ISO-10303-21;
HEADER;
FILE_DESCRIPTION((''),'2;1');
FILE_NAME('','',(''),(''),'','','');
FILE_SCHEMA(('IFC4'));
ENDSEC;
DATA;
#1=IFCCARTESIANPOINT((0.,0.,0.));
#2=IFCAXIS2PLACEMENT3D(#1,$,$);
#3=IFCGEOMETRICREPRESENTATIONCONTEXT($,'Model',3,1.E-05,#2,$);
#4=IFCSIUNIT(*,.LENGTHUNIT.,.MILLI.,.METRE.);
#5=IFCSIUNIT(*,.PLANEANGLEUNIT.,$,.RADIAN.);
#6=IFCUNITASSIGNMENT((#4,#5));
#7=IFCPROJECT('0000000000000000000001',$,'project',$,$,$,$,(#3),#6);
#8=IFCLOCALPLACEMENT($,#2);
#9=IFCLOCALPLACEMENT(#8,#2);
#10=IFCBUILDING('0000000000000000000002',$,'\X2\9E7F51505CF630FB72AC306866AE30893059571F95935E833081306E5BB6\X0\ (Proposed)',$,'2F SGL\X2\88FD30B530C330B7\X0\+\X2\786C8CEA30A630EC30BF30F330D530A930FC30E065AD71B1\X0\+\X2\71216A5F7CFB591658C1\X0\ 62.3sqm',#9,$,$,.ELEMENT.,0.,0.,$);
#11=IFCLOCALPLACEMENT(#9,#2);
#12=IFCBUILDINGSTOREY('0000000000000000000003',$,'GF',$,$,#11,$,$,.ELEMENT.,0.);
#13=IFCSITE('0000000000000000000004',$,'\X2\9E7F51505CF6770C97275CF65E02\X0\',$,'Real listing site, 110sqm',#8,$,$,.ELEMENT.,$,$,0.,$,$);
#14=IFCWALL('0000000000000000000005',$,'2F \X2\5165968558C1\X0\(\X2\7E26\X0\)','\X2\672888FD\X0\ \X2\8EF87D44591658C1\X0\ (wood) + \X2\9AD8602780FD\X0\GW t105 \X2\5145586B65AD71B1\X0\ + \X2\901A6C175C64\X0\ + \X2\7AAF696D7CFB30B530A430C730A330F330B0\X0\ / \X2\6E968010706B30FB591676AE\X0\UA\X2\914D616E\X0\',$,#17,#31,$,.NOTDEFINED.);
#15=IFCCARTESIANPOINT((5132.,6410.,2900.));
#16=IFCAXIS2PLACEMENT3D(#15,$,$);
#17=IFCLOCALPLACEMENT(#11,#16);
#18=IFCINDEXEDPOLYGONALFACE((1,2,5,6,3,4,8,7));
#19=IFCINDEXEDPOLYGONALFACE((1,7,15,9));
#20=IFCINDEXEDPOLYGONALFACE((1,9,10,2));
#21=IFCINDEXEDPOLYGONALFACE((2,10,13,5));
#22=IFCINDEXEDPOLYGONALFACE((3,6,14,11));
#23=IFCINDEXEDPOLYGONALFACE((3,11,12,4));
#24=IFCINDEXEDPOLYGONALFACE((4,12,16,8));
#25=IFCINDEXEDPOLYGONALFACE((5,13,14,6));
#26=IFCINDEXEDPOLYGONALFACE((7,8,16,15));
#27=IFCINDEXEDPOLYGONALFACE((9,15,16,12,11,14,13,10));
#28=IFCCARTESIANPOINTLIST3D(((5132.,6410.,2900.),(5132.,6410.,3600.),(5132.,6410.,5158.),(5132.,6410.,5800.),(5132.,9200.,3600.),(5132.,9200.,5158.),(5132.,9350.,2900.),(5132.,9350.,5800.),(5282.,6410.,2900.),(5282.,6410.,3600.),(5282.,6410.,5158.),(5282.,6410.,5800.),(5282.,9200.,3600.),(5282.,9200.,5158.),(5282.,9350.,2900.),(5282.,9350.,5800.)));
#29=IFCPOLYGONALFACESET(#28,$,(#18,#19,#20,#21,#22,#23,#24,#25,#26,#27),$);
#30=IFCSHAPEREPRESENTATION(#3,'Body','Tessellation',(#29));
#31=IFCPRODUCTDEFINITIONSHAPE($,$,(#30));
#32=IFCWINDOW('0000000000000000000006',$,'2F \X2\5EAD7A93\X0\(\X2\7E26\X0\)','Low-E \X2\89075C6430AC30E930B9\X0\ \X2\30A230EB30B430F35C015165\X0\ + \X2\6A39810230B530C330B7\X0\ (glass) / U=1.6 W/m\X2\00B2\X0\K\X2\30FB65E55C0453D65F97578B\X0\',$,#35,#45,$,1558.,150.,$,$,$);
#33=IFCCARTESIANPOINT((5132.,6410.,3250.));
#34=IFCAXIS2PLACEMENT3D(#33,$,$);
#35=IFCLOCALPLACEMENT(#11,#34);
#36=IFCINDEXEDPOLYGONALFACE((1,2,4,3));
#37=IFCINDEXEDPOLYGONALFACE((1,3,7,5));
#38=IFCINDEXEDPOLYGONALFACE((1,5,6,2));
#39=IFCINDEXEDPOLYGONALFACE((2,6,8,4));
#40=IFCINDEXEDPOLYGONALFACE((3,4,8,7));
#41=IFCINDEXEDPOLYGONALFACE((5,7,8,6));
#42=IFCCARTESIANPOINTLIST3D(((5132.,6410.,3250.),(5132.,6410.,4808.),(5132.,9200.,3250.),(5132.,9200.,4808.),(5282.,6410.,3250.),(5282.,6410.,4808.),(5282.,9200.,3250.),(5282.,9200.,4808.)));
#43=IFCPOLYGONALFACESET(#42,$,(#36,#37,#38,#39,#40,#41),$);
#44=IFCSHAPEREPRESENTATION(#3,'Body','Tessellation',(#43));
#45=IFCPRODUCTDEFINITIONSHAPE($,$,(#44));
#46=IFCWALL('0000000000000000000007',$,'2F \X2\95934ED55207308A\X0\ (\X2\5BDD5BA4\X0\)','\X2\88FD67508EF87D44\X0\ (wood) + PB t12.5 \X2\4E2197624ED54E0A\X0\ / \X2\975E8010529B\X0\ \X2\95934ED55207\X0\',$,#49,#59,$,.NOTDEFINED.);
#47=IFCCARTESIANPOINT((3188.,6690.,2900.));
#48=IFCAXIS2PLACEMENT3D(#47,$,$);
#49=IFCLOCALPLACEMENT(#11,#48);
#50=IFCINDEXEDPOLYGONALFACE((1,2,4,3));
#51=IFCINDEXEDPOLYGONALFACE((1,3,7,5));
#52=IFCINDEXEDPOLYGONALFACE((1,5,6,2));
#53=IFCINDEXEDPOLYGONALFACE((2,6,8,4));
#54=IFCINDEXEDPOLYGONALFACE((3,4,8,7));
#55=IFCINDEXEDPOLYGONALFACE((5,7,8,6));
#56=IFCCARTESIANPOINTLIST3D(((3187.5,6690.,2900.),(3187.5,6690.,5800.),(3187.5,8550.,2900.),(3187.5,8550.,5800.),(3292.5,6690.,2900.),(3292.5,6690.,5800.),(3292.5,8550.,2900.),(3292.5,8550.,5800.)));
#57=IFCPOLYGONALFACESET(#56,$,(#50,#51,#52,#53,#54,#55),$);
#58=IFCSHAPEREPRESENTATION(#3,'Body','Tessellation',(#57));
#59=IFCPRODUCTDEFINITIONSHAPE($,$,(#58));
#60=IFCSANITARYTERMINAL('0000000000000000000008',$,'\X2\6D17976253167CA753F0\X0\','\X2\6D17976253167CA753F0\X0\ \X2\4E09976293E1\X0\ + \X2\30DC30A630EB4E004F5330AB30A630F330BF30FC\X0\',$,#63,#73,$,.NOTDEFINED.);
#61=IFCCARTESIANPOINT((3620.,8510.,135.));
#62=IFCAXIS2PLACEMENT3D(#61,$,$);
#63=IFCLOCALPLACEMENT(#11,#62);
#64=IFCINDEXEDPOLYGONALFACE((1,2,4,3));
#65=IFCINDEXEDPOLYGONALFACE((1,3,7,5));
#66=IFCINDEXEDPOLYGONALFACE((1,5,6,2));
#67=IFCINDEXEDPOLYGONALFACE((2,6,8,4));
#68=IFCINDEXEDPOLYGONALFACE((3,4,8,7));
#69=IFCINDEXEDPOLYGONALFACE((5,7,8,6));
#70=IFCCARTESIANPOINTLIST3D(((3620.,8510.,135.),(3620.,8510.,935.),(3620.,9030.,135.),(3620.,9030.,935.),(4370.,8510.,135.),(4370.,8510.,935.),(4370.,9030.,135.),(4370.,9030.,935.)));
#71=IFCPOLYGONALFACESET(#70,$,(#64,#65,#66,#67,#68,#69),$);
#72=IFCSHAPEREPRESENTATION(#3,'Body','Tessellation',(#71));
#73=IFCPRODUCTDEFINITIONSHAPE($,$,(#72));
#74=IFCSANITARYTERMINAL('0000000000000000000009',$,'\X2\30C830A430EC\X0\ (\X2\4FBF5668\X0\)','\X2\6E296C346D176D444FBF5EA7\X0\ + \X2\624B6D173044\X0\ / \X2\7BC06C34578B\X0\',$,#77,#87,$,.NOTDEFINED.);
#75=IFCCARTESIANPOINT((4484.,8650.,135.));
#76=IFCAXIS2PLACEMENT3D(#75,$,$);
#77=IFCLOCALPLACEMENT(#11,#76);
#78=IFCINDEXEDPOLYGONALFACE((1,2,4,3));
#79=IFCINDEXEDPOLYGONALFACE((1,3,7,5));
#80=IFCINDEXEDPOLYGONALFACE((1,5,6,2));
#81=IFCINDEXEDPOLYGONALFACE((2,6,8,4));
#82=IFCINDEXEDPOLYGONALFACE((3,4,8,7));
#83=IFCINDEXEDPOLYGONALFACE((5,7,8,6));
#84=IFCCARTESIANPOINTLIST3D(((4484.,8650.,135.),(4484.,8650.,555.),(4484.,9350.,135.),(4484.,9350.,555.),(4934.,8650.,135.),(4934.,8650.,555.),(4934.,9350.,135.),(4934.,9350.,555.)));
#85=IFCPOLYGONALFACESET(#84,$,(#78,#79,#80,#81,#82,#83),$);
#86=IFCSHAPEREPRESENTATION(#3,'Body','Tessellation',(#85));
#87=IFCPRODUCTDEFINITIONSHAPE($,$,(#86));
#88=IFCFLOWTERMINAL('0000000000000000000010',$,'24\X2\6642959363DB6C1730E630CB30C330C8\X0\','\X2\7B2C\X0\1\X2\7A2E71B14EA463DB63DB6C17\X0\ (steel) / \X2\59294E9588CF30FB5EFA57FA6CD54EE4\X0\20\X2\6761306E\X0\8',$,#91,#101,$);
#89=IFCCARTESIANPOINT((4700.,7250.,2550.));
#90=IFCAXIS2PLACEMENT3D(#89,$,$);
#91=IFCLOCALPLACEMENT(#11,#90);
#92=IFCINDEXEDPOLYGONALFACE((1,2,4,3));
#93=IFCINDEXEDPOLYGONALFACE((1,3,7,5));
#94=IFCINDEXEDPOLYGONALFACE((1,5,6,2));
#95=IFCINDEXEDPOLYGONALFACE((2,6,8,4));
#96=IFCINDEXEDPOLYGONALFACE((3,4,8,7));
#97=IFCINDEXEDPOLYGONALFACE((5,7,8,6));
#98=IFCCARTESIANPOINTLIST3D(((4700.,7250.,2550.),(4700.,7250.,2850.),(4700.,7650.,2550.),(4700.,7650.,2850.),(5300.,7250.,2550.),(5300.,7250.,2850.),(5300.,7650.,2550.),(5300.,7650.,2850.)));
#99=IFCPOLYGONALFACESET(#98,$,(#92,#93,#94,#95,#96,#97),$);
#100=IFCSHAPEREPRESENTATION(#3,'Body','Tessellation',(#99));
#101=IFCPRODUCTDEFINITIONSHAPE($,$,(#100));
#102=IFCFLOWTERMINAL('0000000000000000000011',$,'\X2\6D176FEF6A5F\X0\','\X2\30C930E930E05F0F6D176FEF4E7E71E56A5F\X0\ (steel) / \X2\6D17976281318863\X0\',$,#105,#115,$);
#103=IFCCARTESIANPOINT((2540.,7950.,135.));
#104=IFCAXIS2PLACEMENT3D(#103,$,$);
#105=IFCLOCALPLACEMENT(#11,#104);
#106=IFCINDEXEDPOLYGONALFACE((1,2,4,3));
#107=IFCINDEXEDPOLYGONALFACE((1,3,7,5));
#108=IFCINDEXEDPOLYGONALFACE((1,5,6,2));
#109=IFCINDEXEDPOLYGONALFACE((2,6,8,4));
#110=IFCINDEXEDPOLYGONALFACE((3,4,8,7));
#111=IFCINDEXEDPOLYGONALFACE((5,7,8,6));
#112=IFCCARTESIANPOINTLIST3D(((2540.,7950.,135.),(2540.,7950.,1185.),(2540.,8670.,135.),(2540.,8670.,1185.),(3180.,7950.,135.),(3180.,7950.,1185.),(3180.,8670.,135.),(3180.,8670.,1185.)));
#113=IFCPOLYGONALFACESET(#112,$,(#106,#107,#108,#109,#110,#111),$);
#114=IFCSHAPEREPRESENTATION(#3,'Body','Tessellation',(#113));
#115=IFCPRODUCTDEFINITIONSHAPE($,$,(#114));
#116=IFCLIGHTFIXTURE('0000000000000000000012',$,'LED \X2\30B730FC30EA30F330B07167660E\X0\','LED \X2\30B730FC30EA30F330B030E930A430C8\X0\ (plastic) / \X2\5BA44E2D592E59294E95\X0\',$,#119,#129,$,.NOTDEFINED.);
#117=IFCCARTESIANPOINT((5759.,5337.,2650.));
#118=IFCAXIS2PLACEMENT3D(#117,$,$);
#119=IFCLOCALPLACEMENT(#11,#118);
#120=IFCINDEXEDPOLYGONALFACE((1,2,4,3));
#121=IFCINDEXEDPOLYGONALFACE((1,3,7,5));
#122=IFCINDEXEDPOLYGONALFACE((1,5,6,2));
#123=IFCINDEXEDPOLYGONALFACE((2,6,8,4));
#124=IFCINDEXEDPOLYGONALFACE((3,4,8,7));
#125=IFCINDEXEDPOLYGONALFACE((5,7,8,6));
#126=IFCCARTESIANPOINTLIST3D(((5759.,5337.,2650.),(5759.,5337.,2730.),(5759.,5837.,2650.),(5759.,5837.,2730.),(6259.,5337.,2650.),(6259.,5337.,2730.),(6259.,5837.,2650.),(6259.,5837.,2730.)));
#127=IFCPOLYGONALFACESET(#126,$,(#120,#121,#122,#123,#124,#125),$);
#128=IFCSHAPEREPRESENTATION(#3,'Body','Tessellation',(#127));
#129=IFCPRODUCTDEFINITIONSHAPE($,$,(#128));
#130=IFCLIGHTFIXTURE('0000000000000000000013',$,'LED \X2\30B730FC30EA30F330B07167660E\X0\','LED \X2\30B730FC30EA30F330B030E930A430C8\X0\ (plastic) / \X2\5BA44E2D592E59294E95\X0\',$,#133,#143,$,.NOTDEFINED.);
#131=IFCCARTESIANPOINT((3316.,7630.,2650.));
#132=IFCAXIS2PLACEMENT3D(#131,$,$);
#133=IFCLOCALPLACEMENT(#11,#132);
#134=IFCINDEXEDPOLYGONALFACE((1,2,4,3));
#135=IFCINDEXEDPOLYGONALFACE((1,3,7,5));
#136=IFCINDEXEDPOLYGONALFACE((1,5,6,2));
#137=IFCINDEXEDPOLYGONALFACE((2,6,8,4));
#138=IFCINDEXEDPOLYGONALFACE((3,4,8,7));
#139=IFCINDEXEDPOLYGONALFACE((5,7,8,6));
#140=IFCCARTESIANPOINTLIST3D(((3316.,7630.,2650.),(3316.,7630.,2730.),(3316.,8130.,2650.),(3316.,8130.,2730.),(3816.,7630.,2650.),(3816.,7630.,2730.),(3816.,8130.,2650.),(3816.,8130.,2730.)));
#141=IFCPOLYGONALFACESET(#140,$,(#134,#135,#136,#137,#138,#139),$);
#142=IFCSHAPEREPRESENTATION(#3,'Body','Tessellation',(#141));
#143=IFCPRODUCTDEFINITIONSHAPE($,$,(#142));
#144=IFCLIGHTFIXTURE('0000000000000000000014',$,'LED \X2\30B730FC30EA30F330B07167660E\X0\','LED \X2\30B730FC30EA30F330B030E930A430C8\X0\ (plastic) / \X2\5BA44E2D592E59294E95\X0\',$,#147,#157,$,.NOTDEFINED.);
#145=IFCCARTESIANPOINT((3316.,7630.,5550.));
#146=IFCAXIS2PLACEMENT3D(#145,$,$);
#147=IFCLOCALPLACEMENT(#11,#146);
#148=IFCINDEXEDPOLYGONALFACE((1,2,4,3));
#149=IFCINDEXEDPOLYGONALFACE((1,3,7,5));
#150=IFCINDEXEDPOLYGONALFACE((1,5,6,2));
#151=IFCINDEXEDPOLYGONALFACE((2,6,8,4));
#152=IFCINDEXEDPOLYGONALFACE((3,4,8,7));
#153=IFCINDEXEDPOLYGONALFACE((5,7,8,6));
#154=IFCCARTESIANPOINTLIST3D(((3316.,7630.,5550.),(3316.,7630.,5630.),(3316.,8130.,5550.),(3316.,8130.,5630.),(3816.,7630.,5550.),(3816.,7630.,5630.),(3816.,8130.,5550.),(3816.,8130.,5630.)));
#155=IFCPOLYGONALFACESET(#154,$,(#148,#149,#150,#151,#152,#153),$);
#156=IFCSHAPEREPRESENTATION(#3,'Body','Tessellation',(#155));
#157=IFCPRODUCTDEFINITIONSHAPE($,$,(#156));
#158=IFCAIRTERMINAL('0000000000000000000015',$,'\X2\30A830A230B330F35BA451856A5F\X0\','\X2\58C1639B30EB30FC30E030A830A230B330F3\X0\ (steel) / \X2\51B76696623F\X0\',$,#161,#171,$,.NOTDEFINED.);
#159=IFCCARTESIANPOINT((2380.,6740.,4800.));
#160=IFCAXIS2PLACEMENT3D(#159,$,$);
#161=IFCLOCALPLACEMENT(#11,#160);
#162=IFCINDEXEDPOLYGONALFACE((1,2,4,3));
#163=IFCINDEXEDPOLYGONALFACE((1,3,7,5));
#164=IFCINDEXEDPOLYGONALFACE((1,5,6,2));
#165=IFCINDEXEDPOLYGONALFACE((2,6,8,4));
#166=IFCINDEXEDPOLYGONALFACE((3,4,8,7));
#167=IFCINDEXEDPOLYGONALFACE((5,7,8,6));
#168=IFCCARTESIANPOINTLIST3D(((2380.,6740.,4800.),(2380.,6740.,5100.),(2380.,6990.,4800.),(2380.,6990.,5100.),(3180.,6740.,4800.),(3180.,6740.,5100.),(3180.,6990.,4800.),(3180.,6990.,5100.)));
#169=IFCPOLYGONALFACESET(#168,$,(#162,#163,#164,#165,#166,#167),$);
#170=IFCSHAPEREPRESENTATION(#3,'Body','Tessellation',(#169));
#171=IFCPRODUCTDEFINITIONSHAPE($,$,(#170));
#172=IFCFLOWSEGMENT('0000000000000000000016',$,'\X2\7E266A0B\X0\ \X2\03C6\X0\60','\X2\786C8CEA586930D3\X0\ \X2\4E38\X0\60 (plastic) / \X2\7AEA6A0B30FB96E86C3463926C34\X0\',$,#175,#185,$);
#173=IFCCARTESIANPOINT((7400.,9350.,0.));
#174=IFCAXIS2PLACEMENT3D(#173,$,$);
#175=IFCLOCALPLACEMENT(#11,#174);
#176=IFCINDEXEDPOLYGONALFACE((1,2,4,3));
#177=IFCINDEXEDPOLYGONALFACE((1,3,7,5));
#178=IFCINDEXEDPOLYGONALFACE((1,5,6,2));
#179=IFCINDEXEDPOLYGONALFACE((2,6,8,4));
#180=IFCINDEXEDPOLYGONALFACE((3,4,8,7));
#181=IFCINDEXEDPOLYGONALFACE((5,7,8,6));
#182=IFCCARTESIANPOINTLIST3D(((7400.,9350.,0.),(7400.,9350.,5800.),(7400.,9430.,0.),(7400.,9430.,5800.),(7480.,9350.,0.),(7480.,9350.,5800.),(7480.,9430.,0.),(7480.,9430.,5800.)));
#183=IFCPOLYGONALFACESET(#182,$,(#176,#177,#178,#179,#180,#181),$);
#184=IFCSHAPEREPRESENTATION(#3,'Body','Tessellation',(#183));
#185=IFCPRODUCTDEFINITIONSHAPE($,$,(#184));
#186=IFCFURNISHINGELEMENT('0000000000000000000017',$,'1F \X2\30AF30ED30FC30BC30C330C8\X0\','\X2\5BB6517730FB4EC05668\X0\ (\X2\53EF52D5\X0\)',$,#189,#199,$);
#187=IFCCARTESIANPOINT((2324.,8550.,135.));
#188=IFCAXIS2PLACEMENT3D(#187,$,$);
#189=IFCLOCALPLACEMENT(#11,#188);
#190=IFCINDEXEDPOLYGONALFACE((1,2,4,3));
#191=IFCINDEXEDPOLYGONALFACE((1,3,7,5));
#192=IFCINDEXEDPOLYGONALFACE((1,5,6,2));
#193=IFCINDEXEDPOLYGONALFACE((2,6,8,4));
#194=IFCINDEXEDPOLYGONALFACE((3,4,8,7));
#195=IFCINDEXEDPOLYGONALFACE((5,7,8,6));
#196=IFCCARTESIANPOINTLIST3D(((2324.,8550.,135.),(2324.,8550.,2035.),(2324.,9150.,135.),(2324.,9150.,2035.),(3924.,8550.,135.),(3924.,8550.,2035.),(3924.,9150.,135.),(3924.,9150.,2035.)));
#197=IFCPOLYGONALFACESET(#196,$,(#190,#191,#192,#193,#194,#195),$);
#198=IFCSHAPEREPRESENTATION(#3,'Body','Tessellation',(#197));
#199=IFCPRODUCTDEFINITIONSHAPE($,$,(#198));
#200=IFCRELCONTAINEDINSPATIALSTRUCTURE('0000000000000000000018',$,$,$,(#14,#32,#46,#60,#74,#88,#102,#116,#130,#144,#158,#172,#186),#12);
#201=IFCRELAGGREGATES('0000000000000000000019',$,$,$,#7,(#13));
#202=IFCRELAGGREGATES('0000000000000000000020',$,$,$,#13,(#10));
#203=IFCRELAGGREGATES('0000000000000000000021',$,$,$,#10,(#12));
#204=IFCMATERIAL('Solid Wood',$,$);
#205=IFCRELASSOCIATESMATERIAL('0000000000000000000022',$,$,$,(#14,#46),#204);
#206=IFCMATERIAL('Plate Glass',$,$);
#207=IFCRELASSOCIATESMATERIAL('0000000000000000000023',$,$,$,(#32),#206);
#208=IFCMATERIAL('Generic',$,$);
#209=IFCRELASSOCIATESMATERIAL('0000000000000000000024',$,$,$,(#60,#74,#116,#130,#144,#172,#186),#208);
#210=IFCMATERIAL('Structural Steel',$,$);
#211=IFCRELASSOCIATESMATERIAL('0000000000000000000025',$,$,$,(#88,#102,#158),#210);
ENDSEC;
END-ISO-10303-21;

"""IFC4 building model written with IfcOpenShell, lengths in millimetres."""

from ifc_helpers import new_model, si_unit, frame, frame_2d, origin, place, context, project, spatial, rectangle, extrude, material, element, fill, save


model = new_model("IFC4")

# Units and contexts
model_context = context("Model", 3, precision=1e-05, world=origin())
ifc_project = project(units=[si_unit("LENGTHUNIT", "METRE", prefix="MILLI"), si_unit("PLANEANGLEUNIT", "RADIAN")], contexts=[model_context])

# Site, building, storey
site_placement = place(None, origin())
site = spatial("IfcSite", under=ifc_project, at=site_placement, Name="鹿児島県霧島市", ObjectType="Real listing site, 110sqm", CompositionType="ELEMENT", RefElevation=0.0)
building_placement = place(site_placement, origin())
building = spatial("IfcBuilding", under=site, at=building_placement, Name="鹿児島・犬と暮らす土間広めの家 (Proposed)", ObjectType="2F SGL製サッシ+硬質ウレタンフォーム断熱+無機系外壁 62.3sqm", CompositionType="ELEMENT", ElevationOfRefHeight=0.0, ElevationOfTerrain=0.0)
storey_placement = place(building_placement, origin())
storey = spatial("IfcBuildingStorey", under=building, at=storey_placement, Name="GF", CompositionType="ELEMENT", Elevation=0.0)

# Shared definitions
ifc_material_1 = material(Name="Solid Wood")

# Shared definitions
ifc_material_2 = material(Name="Plate Glass")

# Wall, opening, window
wall_1_placement = place(storey_placement, frame((5132.0, 6410.0, 2900.0)))
wall_1 = element("IfcWall", 1, at=wall_1_placement, inside=storey, material=ifc_material_1, Name="2F 入隅壁(縦)", Description="木製 軸組外壁 (wood) + 高性能GW t105 充填断熱 + 通気層 + 窯業系サイディング / 準耐火・外皮UA配慮", PredefinedType="NOTDEFINED", context=model_context, shape_type="SweptSolid", body=[
    extrude(rectangle(XDim=150.0, YDim=2940.0, at=frame_2d((75.0, 1470.0))), frame((5132.0, 6410.0, 2900.0)), (0.0, 0.0, 1.0), 2900.0),
])
opening_1_placement = place(storey_placement, frame((5132.0, 6410.0, 3250.0)))
opening_1 = element("IfcOpeningElement", 2, at=opening_1_placement, cuts=wall_1, PredefinedType="NOTDEFINED", context=model_context, shape_type="SweptSolid", body=[
    extrude(rectangle(XDim=150.0, YDim=2790.0, at=frame_2d((75.0, 1395.0))), frame((5132.0, 6410.0, 3250.0)), (0.0, 0.0, 1.0), 1558.0),
])
window_1_placement = place(storey_placement, frame((5132.0, 6410.0, 3250.0)))
window_1 = element("IfcWindow", 3, at=window_1_placement, inside=storey, material=ifc_material_2, Name="2F 庭窓(縦)", Description="Low-E 複層ガラス アルゴン封入 + 樹脂サッシ (glass) / U=1.6 W/m²K・日射取得型", OverallHeight=1558.0, OverallWidth=150.0, context=model_context, shape_type="SweptSolid", body=[
    extrude(rectangle(XDim=150.0, YDim=2790.0, at=frame_2d((75.0, 1395.0))), frame((5132.0, 6410.0, 3250.0)), (0.0, 0.0, 1.0), 1558.0),
])
fill(opening_1, window_1)

# Wall
wall_2_placement = place(storey_placement, frame((3188.0, 6690.0, 2900.0)))
element("IfcWall", 4, at=wall_2_placement, inside=storey, material=ifc_material_1, Name="2F 間仕切り (寝室)", Description="製材軸組 (wood) + PB t12.5 両面仕上 / 非耐力 間仕切", PredefinedType="NOTDEFINED", context=model_context, shape_type="SweptSolid", body=[
    extrude(rectangle(XDim=105.0, YDim=1860.0, at=frame_2d((52.0, 930.0))), frame((3188.0, 6690.0, 2900.0)), (0.0, 0.0, 1.0), 2900.0),
])

# Sanitary terminals
ifc_material_3 = material(Name="Generic")
sanitary_terminal_1_placement = place(storey_placement, frame((3620.0, 8510.0, 135.0)))
element("IfcSanitaryTerminal", 5, at=sanitary_terminal_1_placement, inside=storey, material=ifc_material_3, Name="洗面化粧台", Description="洗面化粧台 三面鏡 + ボウル一体カウンター", PredefinedType="NOTDEFINED", context=model_context, shape_type="SweptSolid", body=[
    extrude(rectangle(XDim=750.0, YDim=520.0, at=frame_2d((375.0, 260.0))), frame((3620.0, 8510.0, 135.0)), (0.0, 0.0, 1.0), 800.0),
])
sanitary_terminal_2_placement = place(storey_placement, frame((4484.0, 8650.0, 135.0)))
element("IfcSanitaryTerminal", 6, at=sanitary_terminal_2_placement, inside=storey, material=ifc_material_3, Name="トイレ (便器)", Description="温水洗浄便座 + 手洗い / 節水型", PredefinedType="NOTDEFINED", context=model_context, shape_type="SweptSolid", body=[
    extrude(rectangle(XDim=450.0, YDim=700.0, at=frame_2d((225.0, 350.0))), frame((4484.0, 8650.0, 135.0)), (0.0, 0.0, 1.0), 420.0),
])

# Flow terminals
ifc_material_4 = material(Name="Structural Steel")
flow_terminal_1_placement = place(storey_placement, frame((4700.0, 7250.0, 2550.0)))
element("IfcFlowTerminal", 7, at=flow_terminal_1_placement, inside=storey, material=ifc_material_4, Name="24時間換気ユニット", Description="第1種熱交換換気 (steel) / 天井裏・建基法令20条の8", context=model_context, shape_type="SweptSolid", body=[
    extrude(rectangle(XDim=600.0, YDim=400.0, at=frame_2d((300.0, 200.0))), frame((4700.0, 7250.0, 2550.0)), (0.0, 0.0, 1.0), 300.0),
])
flow_terminal_2_placement = place(storey_placement, frame((2540.0, 7950.0, 135.0)))
element("IfcFlowTerminal", 8, at=flow_terminal_2_placement, inside=storey, material=ifc_material_4, Name="洗濯機", Description="ドラム式洗濯乾燥機 (steel) / 洗面脱衣", context=model_context, shape_type="SweptSolid", body=[
    extrude(rectangle(XDim=640.0, YDim=720.0, at=frame_2d((320.0, 360.0))), frame((2540.0, 7950.0, 135.0)), (0.0, 0.0, 1.0), 1050.0),
])

# Light fixtures
light_fixture_1_placement = place(storey_placement, frame((5759.0, 5337.0, 2650.0)))
element("IfcLightFixture", 9, at=light_fixture_1_placement, inside=storey, material=ifc_material_3, Name="LED シーリング照明", Description="LED シーリングライト (plastic) / 室中央天井", PredefinedType="NOTDEFINED", context=model_context, shape_type="SweptSolid", body=[
    extrude(rectangle(XDim=500.0, YDim=500.0, at=frame_2d((250.0, 250.0))), frame((5759.0, 5337.0, 2650.0)), (0.0, 0.0, 1.0), 80.0),
])
light_fixture_2_placement = place(storey_placement, frame((3316.0, 7630.0, 2650.0)))
element("IfcLightFixture", 10, at=light_fixture_2_placement, inside=storey, material=ifc_material_3, Name="LED シーリング照明", Description="LED シーリングライト (plastic) / 室中央天井", PredefinedType="NOTDEFINED", context=model_context, shape_type="SweptSolid", body=[
    extrude(rectangle(XDim=500.0, YDim=500.0, at=frame_2d((250.0, 250.0))), frame((3316.0, 7630.0, 2650.0)), (0.0, 0.0, 1.0), 80.0),
])
light_fixture_3_placement = place(storey_placement, frame((3316.0, 7630.0, 5550.0)))
element("IfcLightFixture", 11, at=light_fixture_3_placement, inside=storey, material=ifc_material_3, Name="LED シーリング照明", Description="LED シーリングライト (plastic) / 室中央天井", PredefinedType="NOTDEFINED", context=model_context, shape_type="SweptSolid", body=[
    extrude(rectangle(XDim=500.0, YDim=500.0, at=frame_2d((250.0, 250.0))), frame((3316.0, 7630.0, 5550.0)), (0.0, 0.0, 1.0), 80.0),
])

# Air terminal
air_terminal_placement = place(storey_placement, frame((2380.0, 6740.0, 4800.0)))
element("IfcAirTerminal", 12, at=air_terminal_placement, inside=storey, material=ifc_material_4, Name="エアコン室内機", Description="壁掛ルームエアコン (steel) / 冷暖房", PredefinedType="NOTDEFINED", context=model_context, shape_type="SweptSolid", body=[
    extrude(rectangle(XDim=800.0, YDim=250.0, at=frame_2d((400.0, 125.0))), frame((2380.0, 6740.0, 4800.0)), (0.0, 0.0, 1.0), 300.0),
])

# Flow segment
flow_segment_placement = place(storey_placement, frame((7400.0, 9350.0, 0.0)))
element("IfcFlowSegment", 13, at=flow_segment_placement, inside=storey, material=ifc_material_3, Name="縦樋 φ60", Description="硬質塩ビ 丸60 (plastic) / 竪樋・雨水排水", context=model_context, shape_type="SweptSolid", body=[
    extrude(rectangle(XDim=80.0, YDim=80.0, at=frame_2d((40.0, 40.0))), frame((7400.0, 9350.0, 0.0)), (0.0, 0.0, 1.0), 5800.0),
])

# Furnishing element
furnishing_1_placement = place(storey_placement, frame((2324.0, 8550.0, 135.0)))
element("IfcFurnishingElement", 14, at=furnishing_1_placement, inside=storey, material=ifc_material_3, Name="1F クローゼット", Description="家具・什器 (可動)", context=model_context, shape_type="SweptSolid", body=[
    extrude(rectangle(XDim=1600.0, YDim=600.0, at=frame_2d((800.0, 300.0))), frame((2324.0, 8550.0, 135.0)), (0.0, 0.0, 1.0), 1900.0),
])

save(model, "model.ifc")
